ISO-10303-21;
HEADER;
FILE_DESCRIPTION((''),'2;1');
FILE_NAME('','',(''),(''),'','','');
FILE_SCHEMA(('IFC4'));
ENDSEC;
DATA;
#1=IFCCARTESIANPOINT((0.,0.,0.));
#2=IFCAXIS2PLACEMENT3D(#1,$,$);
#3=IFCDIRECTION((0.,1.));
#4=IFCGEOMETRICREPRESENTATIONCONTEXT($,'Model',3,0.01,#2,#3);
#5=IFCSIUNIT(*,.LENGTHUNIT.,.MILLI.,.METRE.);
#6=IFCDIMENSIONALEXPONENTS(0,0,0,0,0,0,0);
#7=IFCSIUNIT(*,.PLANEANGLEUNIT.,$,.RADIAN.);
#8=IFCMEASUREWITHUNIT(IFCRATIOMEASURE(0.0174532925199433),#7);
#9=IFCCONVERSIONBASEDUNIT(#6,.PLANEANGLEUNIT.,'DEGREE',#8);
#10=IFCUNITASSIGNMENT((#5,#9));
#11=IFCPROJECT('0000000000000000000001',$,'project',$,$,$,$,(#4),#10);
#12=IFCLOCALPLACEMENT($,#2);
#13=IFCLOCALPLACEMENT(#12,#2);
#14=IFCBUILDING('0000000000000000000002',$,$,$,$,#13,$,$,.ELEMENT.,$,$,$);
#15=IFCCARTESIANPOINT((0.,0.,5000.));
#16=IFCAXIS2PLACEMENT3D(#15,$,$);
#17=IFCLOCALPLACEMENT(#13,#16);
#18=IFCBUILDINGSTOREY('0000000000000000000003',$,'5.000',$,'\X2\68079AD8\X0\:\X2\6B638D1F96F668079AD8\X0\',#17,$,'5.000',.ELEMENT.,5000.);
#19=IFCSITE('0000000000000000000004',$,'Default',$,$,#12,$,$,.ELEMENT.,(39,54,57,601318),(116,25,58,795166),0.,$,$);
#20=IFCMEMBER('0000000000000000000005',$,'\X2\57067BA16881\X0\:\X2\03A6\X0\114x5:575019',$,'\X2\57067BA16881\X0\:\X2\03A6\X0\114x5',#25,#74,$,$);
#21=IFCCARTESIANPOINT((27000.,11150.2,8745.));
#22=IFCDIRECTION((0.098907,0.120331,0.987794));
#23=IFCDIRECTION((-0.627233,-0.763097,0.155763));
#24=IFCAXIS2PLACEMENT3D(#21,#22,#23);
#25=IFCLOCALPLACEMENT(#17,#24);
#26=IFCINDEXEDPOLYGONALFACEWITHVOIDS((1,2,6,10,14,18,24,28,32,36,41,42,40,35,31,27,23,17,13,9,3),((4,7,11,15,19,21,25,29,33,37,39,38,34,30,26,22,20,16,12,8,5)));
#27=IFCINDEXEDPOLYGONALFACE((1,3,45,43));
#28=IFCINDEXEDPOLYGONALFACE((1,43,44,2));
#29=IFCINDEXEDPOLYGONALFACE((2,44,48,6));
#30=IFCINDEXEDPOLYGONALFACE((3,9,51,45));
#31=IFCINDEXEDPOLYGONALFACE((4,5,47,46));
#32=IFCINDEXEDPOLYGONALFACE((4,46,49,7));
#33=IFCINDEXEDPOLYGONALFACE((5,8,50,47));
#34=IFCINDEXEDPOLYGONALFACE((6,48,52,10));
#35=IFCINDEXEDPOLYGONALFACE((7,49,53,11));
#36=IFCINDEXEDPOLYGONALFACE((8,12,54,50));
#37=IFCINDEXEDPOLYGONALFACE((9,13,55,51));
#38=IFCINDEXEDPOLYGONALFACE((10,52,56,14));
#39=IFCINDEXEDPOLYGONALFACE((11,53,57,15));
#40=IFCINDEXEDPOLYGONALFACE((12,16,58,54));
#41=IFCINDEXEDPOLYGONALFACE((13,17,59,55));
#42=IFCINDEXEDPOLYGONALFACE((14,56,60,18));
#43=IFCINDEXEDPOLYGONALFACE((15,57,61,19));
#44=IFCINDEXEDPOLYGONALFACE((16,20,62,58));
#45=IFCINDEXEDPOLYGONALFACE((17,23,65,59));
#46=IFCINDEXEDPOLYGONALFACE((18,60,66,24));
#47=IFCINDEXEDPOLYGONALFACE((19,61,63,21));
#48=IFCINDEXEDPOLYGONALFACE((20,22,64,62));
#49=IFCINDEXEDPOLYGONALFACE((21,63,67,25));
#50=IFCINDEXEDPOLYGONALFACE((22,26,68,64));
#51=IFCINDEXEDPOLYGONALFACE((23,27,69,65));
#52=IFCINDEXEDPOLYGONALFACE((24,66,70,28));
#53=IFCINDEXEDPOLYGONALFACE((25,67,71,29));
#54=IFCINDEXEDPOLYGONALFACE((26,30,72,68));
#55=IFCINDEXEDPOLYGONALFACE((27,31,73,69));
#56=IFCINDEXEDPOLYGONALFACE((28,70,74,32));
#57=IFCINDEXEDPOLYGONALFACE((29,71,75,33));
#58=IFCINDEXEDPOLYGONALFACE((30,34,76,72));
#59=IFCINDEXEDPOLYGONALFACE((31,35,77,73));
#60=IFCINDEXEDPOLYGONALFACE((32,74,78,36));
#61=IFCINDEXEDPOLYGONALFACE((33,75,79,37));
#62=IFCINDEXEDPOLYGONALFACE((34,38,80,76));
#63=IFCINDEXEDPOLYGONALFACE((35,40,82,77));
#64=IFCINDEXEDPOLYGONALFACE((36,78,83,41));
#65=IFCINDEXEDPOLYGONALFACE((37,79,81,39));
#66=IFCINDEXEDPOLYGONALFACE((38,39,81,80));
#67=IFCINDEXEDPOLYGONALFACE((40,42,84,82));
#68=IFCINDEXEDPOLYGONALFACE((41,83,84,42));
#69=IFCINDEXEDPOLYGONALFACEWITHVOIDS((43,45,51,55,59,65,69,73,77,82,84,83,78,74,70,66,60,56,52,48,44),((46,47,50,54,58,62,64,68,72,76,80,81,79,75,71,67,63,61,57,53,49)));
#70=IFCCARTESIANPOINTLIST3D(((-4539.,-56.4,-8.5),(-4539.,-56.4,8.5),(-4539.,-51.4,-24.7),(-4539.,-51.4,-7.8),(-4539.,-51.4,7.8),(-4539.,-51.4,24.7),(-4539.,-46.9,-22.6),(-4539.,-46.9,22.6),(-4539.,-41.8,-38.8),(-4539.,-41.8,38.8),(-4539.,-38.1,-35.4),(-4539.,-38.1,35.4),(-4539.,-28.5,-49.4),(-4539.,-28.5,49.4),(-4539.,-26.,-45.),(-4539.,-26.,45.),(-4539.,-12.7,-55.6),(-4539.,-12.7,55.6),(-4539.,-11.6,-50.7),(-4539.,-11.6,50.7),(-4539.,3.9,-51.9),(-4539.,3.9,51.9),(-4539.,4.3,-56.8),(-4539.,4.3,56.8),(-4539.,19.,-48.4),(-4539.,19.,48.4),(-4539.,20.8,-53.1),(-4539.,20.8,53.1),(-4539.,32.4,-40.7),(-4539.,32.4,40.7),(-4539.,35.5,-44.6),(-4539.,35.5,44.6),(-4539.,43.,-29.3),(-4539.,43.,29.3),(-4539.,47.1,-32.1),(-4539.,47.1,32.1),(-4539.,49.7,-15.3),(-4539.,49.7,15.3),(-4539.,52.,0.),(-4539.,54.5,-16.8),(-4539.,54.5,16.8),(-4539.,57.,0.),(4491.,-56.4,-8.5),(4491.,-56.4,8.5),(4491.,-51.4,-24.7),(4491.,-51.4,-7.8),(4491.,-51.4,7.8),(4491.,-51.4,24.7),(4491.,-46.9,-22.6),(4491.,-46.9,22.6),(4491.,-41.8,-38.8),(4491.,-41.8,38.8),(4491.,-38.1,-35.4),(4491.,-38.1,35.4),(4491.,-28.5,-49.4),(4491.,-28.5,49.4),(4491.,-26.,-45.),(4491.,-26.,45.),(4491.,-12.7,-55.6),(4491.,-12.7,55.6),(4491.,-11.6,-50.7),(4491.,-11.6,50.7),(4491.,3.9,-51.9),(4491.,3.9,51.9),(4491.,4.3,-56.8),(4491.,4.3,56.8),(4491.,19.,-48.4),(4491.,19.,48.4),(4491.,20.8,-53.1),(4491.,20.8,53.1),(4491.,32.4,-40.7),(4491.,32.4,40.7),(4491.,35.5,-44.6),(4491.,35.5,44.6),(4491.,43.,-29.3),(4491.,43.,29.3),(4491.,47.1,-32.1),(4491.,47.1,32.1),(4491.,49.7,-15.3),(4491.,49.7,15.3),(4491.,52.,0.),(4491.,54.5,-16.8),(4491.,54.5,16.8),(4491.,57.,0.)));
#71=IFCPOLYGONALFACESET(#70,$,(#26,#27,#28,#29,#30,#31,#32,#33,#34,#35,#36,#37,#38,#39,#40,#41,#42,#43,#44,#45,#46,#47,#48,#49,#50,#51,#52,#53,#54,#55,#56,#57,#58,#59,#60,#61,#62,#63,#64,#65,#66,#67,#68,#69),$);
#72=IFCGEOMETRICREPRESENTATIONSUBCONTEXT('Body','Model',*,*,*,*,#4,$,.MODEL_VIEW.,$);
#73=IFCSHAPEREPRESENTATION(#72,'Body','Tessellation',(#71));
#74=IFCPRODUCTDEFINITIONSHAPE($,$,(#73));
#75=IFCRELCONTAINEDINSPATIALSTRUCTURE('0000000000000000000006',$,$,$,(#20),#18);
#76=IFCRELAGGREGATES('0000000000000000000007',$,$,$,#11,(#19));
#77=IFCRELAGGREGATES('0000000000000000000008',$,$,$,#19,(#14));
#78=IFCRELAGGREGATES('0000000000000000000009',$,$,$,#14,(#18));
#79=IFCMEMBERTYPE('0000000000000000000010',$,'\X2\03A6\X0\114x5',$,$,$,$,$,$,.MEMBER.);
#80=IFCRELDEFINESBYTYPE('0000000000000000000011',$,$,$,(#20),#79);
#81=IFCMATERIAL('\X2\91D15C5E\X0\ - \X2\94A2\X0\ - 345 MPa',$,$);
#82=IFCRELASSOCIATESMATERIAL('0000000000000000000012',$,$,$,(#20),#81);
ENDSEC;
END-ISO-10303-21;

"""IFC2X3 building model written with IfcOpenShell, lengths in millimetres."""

from ifc_helpers import new_model, entity, si_unit, converted_unit, direction, frame, frame_2d, origin, place, context, subcontext, project, spatial, hollow_circle, extrude, source, transform, mapped, material, type_object, type_shapes, element, save


model = new_model("IFC2X3")

# Units and contexts
model_context = context("Model", 3, precision=0.01, world=origin(), true_north=direction((0.0, 1.0)))
body_context = subcontext(model_context, "Body", "Model", "MODEL_VIEW")
ifc_project = project(units=[si_unit("LENGTHUNIT", "METRE", prefix="MILLI"), converted_unit("PLANEANGLEUNIT", "DEGREE", entity("IfcRatioMeasure", 0.0174532925199433), si_unit("PLANEANGLEUNIT", "RADIAN"), dimensions=[0, 0, 0, 0, 0, 0, 0])], contexts=[model_context])

# Site, building, storey
site_placement = place(None, origin())
site = spatial("IfcSite", under=ifc_project, at=site_placement, Name="Default", CompositionType="ELEMENT", RefLatitude=(39, 54, 57, 601318), RefLongitude=(116, 25, 58, 795166), RefElevation=0.0)
building_placement = place(site_placement, origin())
building = spatial("IfcBuilding", under=site, at=building_placement, CompositionType="ELEMENT")
storey_placement = place(building_placement, frame((0.0, 0.0, 5000.0)))
storey = spatial("IfcBuildingStorey", under=building, at=storey_placement, Name="5.000", ObjectType="标高:正负零标高", LongName="5.000", CompositionType="ELEMENT", Elevation=5000.0)

# Member
ifc_material_1 = material(Name="金属 - 钢 - 345 MPa")
member_type_1 = type_object("IfcMemberType", Name="Φ114x5", PredefinedType="MEMBER")
shared_shape_1 = source(origin(), body_context, "Body", "SweptSolid", [
    extrude(hollow_circle(Radius=57.0, WallThickness=5.0, at=frame_2d((0.0, 0.0), x_axis=(1.0, 0.0))), frame((-4539.0, 0.0, 0.0), z_axis=(1.0, 0.0, 0.0), x_axis=(0.0, 1.0, 0.0)), (0.0, 0.0, 1.0), 9030.0),
])
type_shapes(member_type_1, [shared_shape_1])
member_1_placement = place(storey_placement, frame((27000.0, 11150.2, 8745.0), z_axis=(0.098907, 0.120331, 0.987794), x_axis=(-0.627233, -0.763097, 0.155763)))
element("IfcMember", 1, at=member_1_placement, inside=storey, type_object=member_type_1, material=ifc_material_1, Name="圆管梁:Φ114x5:575019", ObjectType="圆管梁:Φ114x5", context=body_context, shape_type="MappedRepresentation", body=[
    mapped(shared_shape_1, transform((0.0, 0.0, 0.0), scale=1.0)),
])

save(model, "model.ifc")
